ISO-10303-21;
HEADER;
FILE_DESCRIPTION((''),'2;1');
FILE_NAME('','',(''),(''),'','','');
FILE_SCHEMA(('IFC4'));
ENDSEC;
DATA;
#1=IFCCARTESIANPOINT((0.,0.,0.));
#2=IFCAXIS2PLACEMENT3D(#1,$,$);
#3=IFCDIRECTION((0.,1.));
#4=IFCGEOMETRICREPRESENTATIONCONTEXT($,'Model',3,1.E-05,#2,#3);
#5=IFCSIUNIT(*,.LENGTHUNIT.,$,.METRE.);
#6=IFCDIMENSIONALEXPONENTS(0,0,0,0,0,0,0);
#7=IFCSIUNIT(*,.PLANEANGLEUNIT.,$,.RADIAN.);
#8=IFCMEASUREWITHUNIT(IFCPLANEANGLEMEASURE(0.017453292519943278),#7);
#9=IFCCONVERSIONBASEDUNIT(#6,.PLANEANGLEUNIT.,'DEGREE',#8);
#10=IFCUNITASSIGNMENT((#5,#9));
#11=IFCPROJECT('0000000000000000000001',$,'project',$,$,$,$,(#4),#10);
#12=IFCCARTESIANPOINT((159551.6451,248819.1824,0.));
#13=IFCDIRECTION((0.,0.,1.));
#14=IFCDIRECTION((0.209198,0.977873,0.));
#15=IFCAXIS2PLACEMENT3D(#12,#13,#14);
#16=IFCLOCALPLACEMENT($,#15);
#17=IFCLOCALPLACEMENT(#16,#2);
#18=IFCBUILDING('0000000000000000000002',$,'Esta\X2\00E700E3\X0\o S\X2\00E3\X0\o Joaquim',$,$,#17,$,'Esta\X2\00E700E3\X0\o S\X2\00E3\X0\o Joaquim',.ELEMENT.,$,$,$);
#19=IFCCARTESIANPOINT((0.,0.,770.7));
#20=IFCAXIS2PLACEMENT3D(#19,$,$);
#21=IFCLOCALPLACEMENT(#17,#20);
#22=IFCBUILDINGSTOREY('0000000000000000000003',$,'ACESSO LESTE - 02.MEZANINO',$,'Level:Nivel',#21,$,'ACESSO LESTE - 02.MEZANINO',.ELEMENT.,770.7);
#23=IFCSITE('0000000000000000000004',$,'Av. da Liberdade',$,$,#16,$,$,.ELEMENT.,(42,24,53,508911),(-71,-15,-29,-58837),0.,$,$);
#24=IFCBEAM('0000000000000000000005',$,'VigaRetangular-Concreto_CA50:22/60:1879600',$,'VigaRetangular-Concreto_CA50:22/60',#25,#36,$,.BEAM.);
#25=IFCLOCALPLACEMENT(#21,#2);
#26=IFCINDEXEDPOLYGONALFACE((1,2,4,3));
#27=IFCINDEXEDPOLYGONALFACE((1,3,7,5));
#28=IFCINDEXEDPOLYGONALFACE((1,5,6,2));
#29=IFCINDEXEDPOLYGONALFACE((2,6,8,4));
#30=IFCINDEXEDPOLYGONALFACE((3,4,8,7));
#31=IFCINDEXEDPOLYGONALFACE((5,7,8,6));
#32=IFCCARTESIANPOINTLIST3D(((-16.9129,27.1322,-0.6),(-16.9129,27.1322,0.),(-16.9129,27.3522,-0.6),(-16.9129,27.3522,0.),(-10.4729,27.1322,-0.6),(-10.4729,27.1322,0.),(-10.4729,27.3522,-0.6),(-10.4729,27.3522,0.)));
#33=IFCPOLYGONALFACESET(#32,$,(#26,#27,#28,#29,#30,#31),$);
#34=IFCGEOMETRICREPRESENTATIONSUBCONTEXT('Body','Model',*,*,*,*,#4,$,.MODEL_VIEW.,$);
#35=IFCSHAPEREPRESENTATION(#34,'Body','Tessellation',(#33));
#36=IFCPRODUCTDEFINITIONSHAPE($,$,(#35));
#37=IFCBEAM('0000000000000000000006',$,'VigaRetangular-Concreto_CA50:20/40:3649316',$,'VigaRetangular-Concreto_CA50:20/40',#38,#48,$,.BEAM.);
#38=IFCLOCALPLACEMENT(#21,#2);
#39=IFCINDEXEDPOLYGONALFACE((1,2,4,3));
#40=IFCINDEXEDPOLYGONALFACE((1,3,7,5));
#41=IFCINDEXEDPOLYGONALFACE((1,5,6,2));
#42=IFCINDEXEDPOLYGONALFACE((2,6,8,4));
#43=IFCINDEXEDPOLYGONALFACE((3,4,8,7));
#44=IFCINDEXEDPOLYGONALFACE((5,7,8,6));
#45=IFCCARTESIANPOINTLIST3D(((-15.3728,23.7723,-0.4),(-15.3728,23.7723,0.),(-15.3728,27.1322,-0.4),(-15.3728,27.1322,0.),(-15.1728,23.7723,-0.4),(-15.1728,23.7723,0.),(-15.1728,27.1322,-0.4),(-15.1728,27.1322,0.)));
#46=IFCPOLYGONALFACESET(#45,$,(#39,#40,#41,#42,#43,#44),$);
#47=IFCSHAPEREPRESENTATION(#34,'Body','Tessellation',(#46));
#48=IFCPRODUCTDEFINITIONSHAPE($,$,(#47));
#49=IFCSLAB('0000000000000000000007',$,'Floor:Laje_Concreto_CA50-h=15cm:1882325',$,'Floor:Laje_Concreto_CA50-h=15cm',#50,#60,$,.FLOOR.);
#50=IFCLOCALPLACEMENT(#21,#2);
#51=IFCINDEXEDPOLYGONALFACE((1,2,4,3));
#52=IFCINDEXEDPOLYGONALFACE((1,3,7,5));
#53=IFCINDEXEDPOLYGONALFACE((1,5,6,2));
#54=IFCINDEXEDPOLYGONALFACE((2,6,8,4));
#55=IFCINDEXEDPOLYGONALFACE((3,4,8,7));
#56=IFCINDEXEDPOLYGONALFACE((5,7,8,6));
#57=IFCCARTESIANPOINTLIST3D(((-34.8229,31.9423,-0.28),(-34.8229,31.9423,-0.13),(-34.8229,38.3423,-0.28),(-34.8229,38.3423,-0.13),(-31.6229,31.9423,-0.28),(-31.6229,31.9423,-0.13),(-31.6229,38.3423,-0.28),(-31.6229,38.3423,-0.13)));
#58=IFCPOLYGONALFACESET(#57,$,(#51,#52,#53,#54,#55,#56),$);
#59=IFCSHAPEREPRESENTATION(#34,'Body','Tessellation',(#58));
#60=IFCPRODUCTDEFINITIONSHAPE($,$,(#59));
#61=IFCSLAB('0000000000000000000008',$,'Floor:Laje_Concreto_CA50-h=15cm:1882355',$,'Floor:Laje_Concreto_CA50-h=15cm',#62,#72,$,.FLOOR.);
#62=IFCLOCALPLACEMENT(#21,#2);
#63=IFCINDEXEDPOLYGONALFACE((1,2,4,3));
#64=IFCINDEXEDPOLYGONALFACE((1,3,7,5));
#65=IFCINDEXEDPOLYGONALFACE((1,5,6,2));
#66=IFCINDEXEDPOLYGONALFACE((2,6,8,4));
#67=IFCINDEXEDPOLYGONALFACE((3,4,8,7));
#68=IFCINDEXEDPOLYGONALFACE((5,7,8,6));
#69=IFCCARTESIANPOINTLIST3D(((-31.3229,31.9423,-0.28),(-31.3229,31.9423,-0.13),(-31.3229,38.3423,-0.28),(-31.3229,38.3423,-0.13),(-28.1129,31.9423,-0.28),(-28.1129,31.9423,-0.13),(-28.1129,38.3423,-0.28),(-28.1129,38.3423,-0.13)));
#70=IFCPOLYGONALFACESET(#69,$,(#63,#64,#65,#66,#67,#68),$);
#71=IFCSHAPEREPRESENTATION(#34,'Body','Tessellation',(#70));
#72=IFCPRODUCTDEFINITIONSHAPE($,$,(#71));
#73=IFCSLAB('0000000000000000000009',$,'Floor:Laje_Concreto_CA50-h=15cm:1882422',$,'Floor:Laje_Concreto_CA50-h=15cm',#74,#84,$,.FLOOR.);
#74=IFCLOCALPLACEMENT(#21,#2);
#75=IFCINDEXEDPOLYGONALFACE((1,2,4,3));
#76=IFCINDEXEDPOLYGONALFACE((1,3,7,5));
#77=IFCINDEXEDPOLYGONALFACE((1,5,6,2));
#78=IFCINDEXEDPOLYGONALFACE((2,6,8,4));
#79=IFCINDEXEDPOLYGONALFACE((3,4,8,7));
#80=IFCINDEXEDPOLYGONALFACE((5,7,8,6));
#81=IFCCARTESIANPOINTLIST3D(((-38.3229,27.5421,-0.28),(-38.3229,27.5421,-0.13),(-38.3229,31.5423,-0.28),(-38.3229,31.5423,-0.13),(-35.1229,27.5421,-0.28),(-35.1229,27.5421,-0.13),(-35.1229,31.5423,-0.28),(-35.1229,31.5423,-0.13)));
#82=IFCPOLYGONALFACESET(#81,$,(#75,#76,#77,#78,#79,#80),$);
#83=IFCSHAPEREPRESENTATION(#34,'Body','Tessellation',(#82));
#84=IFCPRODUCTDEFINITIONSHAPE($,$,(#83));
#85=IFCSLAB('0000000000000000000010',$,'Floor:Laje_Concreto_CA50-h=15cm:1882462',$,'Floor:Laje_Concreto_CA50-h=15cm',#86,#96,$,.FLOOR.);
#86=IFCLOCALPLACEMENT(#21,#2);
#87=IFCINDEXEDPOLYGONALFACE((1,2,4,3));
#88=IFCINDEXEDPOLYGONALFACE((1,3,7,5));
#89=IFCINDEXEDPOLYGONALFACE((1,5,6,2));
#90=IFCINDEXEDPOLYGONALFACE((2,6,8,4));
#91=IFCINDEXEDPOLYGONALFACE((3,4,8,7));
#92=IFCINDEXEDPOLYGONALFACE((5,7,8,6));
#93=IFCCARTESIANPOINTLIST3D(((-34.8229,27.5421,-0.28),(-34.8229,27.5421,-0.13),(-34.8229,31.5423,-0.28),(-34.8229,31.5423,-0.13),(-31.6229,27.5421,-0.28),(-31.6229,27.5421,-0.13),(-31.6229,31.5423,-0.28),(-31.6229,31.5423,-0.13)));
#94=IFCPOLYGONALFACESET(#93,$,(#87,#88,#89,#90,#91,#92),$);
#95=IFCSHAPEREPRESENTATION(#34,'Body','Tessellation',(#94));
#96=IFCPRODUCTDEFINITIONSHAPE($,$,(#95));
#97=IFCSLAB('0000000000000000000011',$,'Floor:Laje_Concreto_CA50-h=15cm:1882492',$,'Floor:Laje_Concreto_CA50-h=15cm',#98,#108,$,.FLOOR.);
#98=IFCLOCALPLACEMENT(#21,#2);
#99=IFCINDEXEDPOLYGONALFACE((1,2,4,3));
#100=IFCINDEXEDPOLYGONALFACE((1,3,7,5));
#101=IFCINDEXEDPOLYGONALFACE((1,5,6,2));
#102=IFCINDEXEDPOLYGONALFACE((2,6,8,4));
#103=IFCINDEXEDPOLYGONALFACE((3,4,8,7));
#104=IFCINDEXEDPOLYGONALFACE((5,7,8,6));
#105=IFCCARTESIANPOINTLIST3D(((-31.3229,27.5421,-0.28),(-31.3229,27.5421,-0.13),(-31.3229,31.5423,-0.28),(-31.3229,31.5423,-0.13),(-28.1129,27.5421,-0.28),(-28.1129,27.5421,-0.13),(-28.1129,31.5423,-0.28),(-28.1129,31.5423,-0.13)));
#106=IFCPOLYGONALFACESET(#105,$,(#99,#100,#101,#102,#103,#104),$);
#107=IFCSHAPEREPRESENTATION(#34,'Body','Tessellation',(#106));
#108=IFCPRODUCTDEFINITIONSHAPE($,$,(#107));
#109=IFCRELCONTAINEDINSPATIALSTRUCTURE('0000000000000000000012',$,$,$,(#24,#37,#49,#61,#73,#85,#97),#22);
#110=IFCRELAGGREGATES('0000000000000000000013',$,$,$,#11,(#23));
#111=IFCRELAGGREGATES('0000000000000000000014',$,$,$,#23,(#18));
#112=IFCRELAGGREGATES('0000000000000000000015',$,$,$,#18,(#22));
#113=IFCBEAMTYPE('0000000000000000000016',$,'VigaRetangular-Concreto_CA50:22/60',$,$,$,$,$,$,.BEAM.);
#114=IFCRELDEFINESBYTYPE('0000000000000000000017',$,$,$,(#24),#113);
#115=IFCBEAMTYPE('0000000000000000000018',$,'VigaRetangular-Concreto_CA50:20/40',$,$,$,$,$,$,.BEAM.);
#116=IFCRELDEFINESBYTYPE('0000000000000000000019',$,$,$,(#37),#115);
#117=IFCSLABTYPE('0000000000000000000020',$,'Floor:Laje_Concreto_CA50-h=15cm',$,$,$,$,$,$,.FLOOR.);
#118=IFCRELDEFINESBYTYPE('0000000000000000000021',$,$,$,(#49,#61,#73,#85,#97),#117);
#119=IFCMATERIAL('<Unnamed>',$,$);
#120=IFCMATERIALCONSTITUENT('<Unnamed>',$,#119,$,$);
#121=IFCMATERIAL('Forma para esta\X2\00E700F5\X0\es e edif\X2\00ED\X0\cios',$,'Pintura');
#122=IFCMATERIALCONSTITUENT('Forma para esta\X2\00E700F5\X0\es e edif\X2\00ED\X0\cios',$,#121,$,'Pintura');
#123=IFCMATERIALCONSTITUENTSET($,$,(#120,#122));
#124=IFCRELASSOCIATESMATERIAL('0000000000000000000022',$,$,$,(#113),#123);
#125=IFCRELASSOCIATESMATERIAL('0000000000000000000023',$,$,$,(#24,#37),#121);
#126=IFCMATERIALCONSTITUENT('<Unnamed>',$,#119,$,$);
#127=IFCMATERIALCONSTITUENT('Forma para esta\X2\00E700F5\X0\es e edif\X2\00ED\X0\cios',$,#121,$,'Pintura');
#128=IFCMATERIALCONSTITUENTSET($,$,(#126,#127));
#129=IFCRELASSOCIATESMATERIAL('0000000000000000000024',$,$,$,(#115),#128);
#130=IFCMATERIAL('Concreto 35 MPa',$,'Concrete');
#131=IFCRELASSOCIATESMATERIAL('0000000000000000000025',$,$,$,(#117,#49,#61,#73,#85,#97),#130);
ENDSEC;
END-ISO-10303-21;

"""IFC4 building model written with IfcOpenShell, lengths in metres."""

from ifc_helpers import new_model, entity, si_unit, converted_unit, direction, frame, origin, place, context, subcontext, project, spatial, indexed_curve, outline, extrude, source, transform, mapped, material, constituent, constituent_set, type_object, type_shapes, element, save


model = new_model("IFC4")

# Units and contexts
model_context = context("Model", 3, precision=1e-05, world=origin(), true_north=direction((0.0, 1.0)))
body_context = subcontext(model_context, "Body", "Model", "MODEL_VIEW")
ifc_project = project(units=[si_unit("LENGTHUNIT", "METRE"), converted_unit("PLANEANGLEUNIT", "DEGREE", entity("IfcPlaneAngleMeasure", 0.017453292519943278), si_unit("PLANEANGLEUNIT", "RADIAN"), dimensions=[0, 0, 0, 0, 0, 0, 0])], contexts=[model_context])

# Site, building, storey
site_placement = place(None, frame((159551.6451, 248819.1824, 0.0), z_axis=(0.0, 0.0, 1.0), x_axis=(0.209198, 0.977873, 0.0)))
site = spatial("IfcSite", under=ifc_project, at=site_placement, Name="Av. da Liberdade", CompositionType="ELEMENT", RefLatitude=(42, 24, 53, 508911), RefLongitude=(-71, -15, -29, -58837), RefElevation=0.0)
building_placement = place(site_placement, origin())
building = spatial("IfcBuilding", under=site, at=building_placement, Name="Estação São Joaquim", LongName="Estação São Joaquim", CompositionType="ELEMENT")
storey_placement = place(building_placement, frame((0.0, 0.0, 770.7)))
storey = spatial("IfcBuildingStorey", under=building, at=storey_placement, Name="ACESSO LESTE - 02.MEZANINO", ObjectType="Level:Nivel", LongName="ACESSO LESTE - 02.MEZANINO", CompositionType="ELEMENT", Elevation=770.7)

# Shared definitions
ifc_material_1 = material(Name="Concreto 35 MPa", Category="Concrete")
ifc_material_2 = material(Name="Forma para estações e edifícios", Category="Pintura")

# Beams
ifc_material_3 = material(Name="<Unnamed>")
ifc_constituent_1 = constituent(ifc_material_3, Name="<Unnamed>")
ifc_constituent_2 = constituent(ifc_material_2, Name="Forma para estações e edifícios", Category="Pintura")
ifc_constituent_set_1 = constituent_set(constituents=[ifc_constituent_1, ifc_constituent_2])
beam_type_1 = type_object("IfcBeamType", Name="VigaRetangular-Concreto_CA50:22/60", PredefinedType="BEAM", material=ifc_constituent_set_1)
shared_shape_1 = source(origin(), body_context, "Body", "SweptSolid", [
    extrude(outline(indexed_curve([(-0.3, -0.11), (0.3, -0.11), (0.3, 0.11), (-0.3, 0.11), (-0.3, -0.11)], self_intersect=False)), frame((-16.9129, 27.2422, 770.4), z_axis=(1.0, 0.0, 0.0), x_axis=(0.0, 0.0, -1.0)), (0.0, 0.0, 1.0), 6.44),
])
type_shapes(beam_type_1, [shared_shape_1])
beam_1_placement = place(storey_placement, frame((0.0, 0.0, -770.7)))
element("IfcBeam", 1, at=beam_1_placement, inside=storey, type_object=beam_type_1, material=ifc_material_2, Name="VigaRetangular-Concreto_CA50:22/60:1879600", ObjectType="VigaRetangular-Concreto_CA50:22/60", PredefinedType="BEAM", context=body_context, shape_type="MappedRepresentation", body=[
    mapped(shared_shape_1, transform((0.0, 0.0, 0.0), scale=1.0)),
])
ifc_constituent_3 = constituent(ifc_material_3, Name="<Unnamed>")
ifc_constituent_4 = constituent(ifc_material_2, Name="Forma para estações e edifícios", Category="Pintura")
ifc_constituent_set_2 = constituent_set(constituents=[ifc_constituent_3, ifc_constituent_4])
beam_type_2 = type_object("IfcBeamType", Name="VigaRetangular-Concreto_CA50:20/40", PredefinedType="BEAM", material=ifc_constituent_set_2)
shared_shape_2 = source(origin(), body_context, "Body", "SweptSolid", [
    extrude(outline(indexed_curve([(-0.1, -0.2), (0.1, -0.2), (0.1, 0.2), (-0.1, 0.2), (-0.1, -0.2)], self_intersect=False)), frame((-15.2728, 27.1322, 770.5), z_axis=(0.0, -1.0, 0.0), x_axis=(-1.0, 0.0, 0.0)), (0.0, 0.0, 1.0), 3.3599),
])
type_shapes(beam_type_2, [shared_shape_2])
beam_2_placement = place(storey_placement, frame((0.0, 0.0, -770.7)))
element("IfcBeam", 2, at=beam_2_placement, inside=storey, type_object=beam_type_2, material=ifc_material_2, Name="VigaRetangular-Concreto_CA50:20/40:3649316", ObjectType="VigaRetangular-Concreto_CA50:20/40", PredefinedType="BEAM", context=body_context, shape_type="MappedRepresentation", body=[
    mapped(shared_shape_2, transform((0.0, 0.0, 0.0), scale=1.0)),
])

# Slabs
slab_type = type_object("IfcSlabType", Name="Floor:Laje_Concreto_CA50-h=15cm", PredefinedType="FLOOR", material=ifc_material_1)
slab_1_placement = place(storey_placement, origin())
element("IfcSlab", 3, at=slab_1_placement, inside=storey, type_object=slab_type, material=ifc_material_1, Name="Floor:Laje_Concreto_CA50-h=15cm:1882325", ObjectType="Floor:Laje_Concreto_CA50-h=15cm", PredefinedType="FLOOR", context=body_context, shape_type="SweptSolid", body=[
    extrude(outline(indexed_curve([(-3.2, -1.6), (3.2, -1.6), (3.2, 1.6), (-3.2, 1.6), (-3.2, -1.6)], self_intersect=False)), frame((-33.2229, 35.1423, -0.13), z_axis=(0.0, 0.0, -1.0), x_axis=(0.0, -1.0, 0.0)), (0.0, 0.0, 1.0), 0.15),
])
slab_2_placement = place(storey_placement, origin())
element("IfcSlab", 4, at=slab_2_placement, inside=storey, type_object=slab_type, material=ifc_material_1, Name="Floor:Laje_Concreto_CA50-h=15cm:1882355", ObjectType="Floor:Laje_Concreto_CA50-h=15cm", PredefinedType="FLOOR", context=body_context, shape_type="SweptSolid", body=[
    extrude(outline(indexed_curve([(-3.2, -1.605), (3.2, -1.605), (3.2, 1.605), (-3.2, 1.605), (-3.2, -1.605)], self_intersect=False)), frame((-29.7179, 35.1423, -0.13), z_axis=(0.0, 0.0, -1.0), x_axis=(0.0, -1.0, 0.0)), (0.0, 0.0, 1.0), 0.15),
])
slab_3_placement = place(storey_placement, origin())
element("IfcSlab", 5, at=slab_3_placement, inside=storey, type_object=slab_type, material=ifc_material_1, Name="Floor:Laje_Concreto_CA50-h=15cm:1882422", ObjectType="Floor:Laje_Concreto_CA50-h=15cm", PredefinedType="FLOOR", context=body_context, shape_type="SweptSolid", body=[
    extrude(outline(indexed_curve([(-2.0001, -1.6), (2.0001, -1.6), (2.0001, 1.6), (-2.0001, 1.6), (-2.0001, -1.6)], self_intersect=False)), frame((-36.7229, 29.5422, -0.13), z_axis=(0.0, 0.0, -1.0), x_axis=(0.0, -1.0, 0.0)), (0.0, 0.0, 1.0), 0.15),
])
slab_4_placement = place(storey_placement, origin())
element("IfcSlab", 6, at=slab_4_placement, inside=storey, type_object=slab_type, material=ifc_material_1, Name="Floor:Laje_Concreto_CA50-h=15cm:1882462", ObjectType="Floor:Laje_Concreto_CA50-h=15cm", PredefinedType="FLOOR", context=body_context, shape_type="SweptSolid", body=[
    extrude(outline(indexed_curve([(-2.0001, -1.6), (2.0001, -1.6), (2.0001, 1.6), (-2.0001, 1.6), (-2.0001, -1.6)], self_intersect=False)), frame((-33.2229, 29.5422, -0.13), z_axis=(0.0, 0.0, -1.0), x_axis=(0.0, -1.0, 0.0)), (0.0, 0.0, 1.0), 0.15),
])
slab_5_placement = place(storey_placement, origin())
element("IfcSlab", 7, at=slab_5_placement, inside=storey, type_object=slab_type, material=ifc_material_1, Name="Floor:Laje_Concreto_CA50-h=15cm:1882492", ObjectType="Floor:Laje_Concreto_CA50-h=15cm", PredefinedType="FLOOR", context=body_context, shape_type="SweptSolid", body=[
    extrude(outline(indexed_curve([(-2.0001, -1.605), (2.0001, -1.605), (2.0001, 1.605), (-2.0001, 1.605), (-2.0001, -1.605)], self_intersect=False)), frame((-29.7179, 29.5422, -0.13), z_axis=(0.0, 0.0, -1.0), x_axis=(0.0, -1.0, 0.0)), (0.0, 0.0, 1.0), 0.15),
])

save(model, "model.ifc")
